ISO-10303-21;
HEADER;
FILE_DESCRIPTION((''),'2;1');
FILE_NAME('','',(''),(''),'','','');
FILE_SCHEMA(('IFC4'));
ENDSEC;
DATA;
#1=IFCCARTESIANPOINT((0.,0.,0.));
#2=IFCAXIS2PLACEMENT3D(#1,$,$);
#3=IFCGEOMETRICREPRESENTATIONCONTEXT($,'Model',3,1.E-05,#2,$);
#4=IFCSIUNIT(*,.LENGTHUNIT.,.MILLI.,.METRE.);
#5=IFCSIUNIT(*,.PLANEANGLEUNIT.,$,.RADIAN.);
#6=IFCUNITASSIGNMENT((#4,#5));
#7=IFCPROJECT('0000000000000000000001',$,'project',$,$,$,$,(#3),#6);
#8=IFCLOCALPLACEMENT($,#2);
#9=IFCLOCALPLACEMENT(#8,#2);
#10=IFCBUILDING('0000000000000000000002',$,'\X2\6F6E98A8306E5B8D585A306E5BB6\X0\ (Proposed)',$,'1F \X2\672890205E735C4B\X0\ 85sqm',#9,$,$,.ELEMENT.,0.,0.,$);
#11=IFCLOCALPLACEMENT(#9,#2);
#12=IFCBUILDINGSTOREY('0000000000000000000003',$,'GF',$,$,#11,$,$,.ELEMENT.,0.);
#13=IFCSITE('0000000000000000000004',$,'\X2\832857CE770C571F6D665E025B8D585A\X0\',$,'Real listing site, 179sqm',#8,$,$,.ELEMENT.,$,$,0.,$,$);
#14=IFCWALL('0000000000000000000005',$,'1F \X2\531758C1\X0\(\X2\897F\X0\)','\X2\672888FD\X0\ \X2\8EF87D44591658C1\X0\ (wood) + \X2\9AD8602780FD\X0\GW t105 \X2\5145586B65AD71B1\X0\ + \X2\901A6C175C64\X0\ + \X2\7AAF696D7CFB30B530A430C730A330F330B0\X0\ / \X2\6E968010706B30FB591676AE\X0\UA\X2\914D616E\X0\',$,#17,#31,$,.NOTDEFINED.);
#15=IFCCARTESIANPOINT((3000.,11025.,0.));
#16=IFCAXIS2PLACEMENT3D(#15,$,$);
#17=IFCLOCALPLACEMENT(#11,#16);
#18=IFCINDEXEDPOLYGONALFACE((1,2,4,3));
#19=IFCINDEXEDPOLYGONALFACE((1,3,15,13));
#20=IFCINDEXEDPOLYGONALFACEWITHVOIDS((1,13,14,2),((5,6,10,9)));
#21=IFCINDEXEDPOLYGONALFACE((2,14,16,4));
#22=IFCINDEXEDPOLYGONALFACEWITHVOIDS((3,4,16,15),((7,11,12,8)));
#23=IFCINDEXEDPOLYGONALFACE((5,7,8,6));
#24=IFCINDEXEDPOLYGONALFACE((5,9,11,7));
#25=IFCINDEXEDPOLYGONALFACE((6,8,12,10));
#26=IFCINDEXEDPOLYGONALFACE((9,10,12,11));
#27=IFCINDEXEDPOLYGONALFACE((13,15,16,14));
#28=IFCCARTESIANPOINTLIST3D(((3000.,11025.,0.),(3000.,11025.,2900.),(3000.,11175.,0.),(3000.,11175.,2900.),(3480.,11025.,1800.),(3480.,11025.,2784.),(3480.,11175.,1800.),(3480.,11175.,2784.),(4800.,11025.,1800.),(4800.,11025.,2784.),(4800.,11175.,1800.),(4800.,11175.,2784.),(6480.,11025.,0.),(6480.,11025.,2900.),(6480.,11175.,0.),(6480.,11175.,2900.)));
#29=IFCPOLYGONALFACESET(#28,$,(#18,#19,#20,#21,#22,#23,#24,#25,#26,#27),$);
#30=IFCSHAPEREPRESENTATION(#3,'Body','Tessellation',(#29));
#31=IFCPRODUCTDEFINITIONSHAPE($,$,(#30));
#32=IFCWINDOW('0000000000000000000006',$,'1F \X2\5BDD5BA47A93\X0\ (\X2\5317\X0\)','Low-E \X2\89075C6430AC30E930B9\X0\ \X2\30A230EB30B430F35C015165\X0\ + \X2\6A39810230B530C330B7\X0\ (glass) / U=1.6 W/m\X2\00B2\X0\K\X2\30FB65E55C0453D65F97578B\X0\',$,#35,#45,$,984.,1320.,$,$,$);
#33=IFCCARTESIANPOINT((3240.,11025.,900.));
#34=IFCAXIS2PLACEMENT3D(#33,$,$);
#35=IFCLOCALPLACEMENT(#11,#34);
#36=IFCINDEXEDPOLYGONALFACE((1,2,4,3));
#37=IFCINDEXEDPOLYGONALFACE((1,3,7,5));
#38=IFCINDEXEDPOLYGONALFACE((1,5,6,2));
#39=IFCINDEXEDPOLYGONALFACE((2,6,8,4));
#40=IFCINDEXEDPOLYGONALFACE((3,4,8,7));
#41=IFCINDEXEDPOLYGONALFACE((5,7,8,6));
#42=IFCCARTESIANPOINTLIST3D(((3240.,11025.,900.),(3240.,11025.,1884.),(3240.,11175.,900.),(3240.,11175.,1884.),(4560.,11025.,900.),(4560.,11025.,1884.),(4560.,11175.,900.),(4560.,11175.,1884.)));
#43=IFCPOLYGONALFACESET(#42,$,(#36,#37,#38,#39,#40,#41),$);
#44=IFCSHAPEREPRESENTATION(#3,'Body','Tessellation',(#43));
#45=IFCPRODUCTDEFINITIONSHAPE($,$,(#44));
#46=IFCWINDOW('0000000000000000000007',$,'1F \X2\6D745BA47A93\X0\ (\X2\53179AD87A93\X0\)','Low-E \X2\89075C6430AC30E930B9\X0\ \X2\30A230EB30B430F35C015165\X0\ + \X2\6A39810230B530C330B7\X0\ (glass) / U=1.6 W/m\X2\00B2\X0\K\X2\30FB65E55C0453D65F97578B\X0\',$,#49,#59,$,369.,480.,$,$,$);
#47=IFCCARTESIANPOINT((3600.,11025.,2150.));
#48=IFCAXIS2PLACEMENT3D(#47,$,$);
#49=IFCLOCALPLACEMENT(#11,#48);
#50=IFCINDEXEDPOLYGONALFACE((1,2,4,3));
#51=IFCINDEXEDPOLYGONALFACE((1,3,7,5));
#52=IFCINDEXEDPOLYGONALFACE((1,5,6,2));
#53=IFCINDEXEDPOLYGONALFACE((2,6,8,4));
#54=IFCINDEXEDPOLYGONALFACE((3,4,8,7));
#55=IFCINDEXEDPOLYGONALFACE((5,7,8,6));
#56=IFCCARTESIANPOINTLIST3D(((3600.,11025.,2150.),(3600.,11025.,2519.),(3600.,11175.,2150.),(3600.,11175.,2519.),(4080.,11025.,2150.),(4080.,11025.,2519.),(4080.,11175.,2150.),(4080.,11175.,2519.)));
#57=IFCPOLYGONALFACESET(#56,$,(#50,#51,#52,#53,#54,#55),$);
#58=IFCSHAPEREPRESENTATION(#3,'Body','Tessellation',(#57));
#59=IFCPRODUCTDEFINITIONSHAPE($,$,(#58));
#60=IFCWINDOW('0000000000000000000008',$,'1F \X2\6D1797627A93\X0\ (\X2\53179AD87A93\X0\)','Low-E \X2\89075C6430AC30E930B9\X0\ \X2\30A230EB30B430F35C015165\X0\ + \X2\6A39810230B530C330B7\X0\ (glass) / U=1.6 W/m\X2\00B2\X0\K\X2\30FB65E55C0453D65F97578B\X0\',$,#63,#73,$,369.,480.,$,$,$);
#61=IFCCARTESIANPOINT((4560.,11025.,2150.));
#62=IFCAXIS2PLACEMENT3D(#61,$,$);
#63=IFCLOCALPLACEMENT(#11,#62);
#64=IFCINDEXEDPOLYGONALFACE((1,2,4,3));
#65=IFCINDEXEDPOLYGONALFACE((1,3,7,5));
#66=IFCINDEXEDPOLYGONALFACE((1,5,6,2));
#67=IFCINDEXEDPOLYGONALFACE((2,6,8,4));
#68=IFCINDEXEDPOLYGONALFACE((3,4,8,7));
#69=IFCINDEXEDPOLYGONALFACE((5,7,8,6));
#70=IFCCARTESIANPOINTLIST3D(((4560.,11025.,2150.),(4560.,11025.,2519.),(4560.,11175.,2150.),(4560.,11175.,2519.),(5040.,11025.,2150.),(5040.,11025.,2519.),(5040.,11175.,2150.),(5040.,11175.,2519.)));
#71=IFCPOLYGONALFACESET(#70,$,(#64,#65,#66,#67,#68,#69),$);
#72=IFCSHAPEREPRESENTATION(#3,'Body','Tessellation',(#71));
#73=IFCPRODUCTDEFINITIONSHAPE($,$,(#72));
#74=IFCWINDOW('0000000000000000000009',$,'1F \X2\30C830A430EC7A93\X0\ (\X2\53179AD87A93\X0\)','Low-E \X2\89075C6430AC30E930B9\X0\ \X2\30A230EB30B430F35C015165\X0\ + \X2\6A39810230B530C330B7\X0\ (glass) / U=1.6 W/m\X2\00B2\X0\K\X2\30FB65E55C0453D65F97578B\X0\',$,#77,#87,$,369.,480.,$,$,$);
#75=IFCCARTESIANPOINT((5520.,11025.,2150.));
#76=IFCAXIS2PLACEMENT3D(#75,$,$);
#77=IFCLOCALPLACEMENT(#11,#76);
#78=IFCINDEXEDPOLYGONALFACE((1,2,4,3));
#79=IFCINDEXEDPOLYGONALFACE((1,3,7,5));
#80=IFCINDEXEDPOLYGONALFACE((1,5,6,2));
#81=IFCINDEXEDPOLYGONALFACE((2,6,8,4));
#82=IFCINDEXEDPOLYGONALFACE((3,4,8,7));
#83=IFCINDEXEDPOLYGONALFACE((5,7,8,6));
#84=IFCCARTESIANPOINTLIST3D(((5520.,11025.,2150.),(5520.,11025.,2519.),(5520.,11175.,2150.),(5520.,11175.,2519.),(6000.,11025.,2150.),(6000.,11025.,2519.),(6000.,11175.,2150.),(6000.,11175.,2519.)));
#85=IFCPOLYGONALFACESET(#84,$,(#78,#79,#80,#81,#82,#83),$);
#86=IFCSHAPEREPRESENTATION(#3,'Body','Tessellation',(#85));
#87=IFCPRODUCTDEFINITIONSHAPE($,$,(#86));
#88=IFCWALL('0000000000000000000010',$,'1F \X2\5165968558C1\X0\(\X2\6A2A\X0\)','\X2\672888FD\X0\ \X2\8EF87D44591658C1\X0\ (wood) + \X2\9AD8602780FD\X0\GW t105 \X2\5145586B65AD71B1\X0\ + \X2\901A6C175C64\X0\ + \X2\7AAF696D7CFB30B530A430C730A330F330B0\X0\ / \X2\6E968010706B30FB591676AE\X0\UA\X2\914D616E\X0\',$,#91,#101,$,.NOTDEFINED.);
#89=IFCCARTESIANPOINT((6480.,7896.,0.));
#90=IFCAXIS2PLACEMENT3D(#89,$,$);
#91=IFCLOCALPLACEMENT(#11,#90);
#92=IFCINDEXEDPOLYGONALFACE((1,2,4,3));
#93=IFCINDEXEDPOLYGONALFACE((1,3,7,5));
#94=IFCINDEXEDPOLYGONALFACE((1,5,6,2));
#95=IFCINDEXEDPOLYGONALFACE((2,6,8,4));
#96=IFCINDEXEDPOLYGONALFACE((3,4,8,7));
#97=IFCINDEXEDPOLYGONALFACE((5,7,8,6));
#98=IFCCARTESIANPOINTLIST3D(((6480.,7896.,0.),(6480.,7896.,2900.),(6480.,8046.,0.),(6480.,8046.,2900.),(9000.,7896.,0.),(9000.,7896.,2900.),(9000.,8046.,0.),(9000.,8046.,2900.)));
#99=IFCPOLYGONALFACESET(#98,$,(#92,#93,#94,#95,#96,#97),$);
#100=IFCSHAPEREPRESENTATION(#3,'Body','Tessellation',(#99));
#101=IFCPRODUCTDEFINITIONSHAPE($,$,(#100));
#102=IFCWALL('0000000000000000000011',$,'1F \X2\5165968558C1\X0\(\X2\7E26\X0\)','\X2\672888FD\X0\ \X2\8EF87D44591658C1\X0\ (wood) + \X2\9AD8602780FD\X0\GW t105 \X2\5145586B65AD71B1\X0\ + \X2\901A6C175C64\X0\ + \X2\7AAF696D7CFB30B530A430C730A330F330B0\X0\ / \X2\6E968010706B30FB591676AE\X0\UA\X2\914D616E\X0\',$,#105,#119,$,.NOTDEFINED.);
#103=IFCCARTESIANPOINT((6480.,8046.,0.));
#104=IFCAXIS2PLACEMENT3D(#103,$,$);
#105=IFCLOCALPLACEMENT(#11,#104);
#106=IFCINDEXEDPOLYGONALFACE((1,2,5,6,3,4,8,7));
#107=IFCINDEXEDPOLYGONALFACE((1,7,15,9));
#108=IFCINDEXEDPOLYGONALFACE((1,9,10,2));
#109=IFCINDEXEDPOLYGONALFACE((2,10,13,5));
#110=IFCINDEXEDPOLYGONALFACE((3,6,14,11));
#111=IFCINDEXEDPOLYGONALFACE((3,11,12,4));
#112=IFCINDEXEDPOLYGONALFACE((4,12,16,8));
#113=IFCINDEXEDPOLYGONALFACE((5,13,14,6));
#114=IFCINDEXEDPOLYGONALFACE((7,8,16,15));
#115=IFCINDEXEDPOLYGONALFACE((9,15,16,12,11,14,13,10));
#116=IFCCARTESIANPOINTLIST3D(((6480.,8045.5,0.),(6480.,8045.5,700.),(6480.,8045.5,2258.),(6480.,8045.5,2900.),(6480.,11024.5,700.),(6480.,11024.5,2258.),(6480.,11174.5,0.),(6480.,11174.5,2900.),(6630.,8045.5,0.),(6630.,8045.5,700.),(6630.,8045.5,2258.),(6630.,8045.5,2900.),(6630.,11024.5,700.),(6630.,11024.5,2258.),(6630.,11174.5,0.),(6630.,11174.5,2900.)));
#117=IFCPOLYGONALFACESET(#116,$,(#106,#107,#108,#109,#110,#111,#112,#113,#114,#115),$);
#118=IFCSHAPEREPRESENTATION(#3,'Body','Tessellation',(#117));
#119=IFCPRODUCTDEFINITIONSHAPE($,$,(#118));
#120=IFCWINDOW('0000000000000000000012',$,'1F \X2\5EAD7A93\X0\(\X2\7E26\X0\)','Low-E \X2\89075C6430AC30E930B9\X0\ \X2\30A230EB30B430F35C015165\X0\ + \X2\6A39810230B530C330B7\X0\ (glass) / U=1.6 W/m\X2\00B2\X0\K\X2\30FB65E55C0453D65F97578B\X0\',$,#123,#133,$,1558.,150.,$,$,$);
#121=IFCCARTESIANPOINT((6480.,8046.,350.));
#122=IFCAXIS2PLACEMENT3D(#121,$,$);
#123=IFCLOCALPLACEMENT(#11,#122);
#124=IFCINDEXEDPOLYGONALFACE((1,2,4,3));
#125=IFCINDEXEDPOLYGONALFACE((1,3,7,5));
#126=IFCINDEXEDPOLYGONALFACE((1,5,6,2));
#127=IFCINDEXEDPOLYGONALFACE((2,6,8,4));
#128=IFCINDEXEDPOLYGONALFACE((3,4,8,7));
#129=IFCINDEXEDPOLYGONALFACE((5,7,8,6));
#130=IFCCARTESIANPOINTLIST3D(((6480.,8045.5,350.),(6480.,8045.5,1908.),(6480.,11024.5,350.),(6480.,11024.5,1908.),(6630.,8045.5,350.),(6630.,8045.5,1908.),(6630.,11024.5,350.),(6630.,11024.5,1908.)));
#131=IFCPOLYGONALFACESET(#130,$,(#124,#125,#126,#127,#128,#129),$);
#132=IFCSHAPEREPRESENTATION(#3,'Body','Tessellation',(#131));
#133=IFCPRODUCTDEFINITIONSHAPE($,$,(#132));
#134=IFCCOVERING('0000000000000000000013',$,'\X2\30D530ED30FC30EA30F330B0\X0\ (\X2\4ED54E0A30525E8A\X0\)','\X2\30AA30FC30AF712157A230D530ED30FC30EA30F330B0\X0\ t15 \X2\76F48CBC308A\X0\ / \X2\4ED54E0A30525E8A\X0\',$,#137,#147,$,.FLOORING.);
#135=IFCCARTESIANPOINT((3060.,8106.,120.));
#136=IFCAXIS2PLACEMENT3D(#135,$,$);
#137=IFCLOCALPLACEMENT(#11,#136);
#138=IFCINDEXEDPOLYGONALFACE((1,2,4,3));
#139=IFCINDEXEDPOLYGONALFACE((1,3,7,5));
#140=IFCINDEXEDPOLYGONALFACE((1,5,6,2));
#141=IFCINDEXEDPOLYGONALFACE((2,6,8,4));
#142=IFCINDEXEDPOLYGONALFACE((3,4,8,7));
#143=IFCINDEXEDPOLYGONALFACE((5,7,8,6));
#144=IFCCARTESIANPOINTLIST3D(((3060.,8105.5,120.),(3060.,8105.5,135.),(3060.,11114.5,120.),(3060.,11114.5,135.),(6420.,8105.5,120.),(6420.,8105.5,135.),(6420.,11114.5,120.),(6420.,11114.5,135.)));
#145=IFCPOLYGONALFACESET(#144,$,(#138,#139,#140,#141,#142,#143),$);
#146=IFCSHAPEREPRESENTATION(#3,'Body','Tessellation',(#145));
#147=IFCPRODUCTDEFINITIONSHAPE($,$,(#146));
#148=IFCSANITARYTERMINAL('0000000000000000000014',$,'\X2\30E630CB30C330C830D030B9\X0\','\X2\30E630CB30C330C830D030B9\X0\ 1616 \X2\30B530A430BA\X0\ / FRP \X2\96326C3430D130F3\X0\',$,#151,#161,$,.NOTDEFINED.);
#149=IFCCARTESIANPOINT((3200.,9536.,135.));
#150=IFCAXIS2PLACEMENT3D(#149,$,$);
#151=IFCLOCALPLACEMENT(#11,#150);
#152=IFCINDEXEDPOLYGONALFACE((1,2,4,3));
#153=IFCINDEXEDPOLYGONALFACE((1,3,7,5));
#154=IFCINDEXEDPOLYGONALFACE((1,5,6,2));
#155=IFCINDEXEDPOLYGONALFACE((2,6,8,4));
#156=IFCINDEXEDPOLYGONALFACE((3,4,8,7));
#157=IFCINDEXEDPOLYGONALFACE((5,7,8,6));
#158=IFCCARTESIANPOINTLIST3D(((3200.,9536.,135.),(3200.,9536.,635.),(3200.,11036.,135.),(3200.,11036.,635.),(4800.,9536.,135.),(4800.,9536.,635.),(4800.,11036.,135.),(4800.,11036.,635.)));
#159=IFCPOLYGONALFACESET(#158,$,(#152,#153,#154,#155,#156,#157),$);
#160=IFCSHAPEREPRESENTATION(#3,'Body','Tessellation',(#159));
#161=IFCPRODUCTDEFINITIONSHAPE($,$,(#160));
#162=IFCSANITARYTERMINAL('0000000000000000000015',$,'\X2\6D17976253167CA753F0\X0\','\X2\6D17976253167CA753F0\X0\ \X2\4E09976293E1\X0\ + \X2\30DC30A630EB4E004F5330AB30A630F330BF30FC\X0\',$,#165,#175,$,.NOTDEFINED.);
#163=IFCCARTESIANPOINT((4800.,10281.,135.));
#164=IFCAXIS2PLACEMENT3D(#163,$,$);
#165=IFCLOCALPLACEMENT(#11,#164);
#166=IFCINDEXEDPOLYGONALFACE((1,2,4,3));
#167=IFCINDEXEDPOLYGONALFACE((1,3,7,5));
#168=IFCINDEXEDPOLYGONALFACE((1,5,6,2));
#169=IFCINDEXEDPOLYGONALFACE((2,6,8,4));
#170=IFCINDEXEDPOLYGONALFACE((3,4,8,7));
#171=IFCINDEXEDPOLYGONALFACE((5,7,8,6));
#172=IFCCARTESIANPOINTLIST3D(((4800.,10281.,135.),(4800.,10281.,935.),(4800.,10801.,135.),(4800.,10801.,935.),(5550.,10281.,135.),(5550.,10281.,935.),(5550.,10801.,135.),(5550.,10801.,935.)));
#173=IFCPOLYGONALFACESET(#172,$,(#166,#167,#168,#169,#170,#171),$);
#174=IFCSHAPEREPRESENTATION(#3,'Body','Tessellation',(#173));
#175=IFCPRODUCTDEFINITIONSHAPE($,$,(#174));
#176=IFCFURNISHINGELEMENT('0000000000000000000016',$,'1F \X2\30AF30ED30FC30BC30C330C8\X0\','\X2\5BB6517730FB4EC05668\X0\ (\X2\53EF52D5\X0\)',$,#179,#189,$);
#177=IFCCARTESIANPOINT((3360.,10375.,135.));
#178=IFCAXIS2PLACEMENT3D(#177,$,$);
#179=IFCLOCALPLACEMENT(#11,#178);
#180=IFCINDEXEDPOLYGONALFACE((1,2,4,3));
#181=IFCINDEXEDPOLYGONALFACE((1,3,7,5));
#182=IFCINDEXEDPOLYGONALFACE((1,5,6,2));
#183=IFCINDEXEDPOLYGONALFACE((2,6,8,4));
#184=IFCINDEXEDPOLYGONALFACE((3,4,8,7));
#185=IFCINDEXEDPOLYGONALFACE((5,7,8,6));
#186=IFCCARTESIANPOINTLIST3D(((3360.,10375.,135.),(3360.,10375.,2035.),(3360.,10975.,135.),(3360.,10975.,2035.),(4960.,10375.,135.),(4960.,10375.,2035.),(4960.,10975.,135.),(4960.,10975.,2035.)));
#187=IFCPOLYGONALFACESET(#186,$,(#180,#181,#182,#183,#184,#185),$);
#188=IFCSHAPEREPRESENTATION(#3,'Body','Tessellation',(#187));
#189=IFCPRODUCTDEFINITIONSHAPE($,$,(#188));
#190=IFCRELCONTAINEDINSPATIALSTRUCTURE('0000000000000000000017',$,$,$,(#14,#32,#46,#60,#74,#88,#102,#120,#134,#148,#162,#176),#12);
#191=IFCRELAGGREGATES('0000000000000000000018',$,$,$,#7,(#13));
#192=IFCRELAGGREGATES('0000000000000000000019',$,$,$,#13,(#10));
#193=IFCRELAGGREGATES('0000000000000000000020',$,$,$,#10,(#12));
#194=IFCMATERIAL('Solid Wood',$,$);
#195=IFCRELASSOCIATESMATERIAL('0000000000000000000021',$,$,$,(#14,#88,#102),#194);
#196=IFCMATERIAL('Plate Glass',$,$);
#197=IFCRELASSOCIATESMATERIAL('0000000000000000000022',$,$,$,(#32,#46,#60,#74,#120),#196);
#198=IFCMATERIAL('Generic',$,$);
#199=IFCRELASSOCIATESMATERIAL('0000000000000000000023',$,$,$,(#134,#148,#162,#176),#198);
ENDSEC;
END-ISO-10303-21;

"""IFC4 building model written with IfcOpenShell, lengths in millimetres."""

from ifc_helpers import new_model, si_unit, frame, frame_2d, origin, place, context, project, spatial, rectangle, extrude, material, element, fill, save


model = new_model("IFC4")

# Units and contexts
model_context = context("Model", 3, precision=1e-05, world=origin())
ifc_project = project(units=[si_unit("LENGTHUNIT", "METRE", prefix="MILLI"), si_unit("PLANEANGLEUNIT", "RADIAN")], contexts=[model_context])

# Site, building, storey
site_placement = place(None, origin())
site = spatial("IfcSite", under=ifc_project, at=site_placement, Name="茨城県土浦市宍塚", ObjectType="Real listing site, 179sqm", CompositionType="ELEMENT", RefElevation=0.0)
building_placement = place(site_placement, origin())
building = spatial("IfcBuilding", under=site, at=building_placement, Name="潮風の宍塚の家 (Proposed)", ObjectType="1F 木造平屋 85sqm", CompositionType="ELEMENT", ElevationOfRefHeight=0.0, ElevationOfTerrain=0.0)
storey_placement = place(building_placement, origin())
storey = spatial("IfcBuildingStorey", under=building, at=storey_placement, Name="GF", CompositionType="ELEMENT", Elevation=0.0)

# Shared definitions
ifc_material_1 = material(Name="Solid Wood")

# Wall, openings, windows
wall_1_placement = place(storey_placement, frame((3000.0, 11025.0, 0.0)))
wall_1 = element("IfcWall", 1, at=wall_1_placement, inside=storey, material=ifc_material_1, Name="1F 北壁(西)", Description="木製 軸組外壁 (wood) + 高性能GW t105 充填断熱 + 通気層 + 窯業系サイディング / 準耐火・外皮UA配慮", PredefinedType="NOTDEFINED", context=model_context, shape_type="SweptSolid", body=[
    extrude(rectangle(XDim=3480.0, YDim=150.0, at=frame_2d((1740.0, 75.0))), frame((3000.0, 11025.0, 0.0)), (0.0, 0.0, 1.0), 2900.0),
])
opening_1_placement = place(storey_placement, frame((3240.0, 11025.0, 900.0)))
opening_1 = element("IfcOpeningElement", 2, at=opening_1_placement, cuts=wall_1, PredefinedType="NOTDEFINED", context=model_context, shape_type="SweptSolid", body=[
    extrude(rectangle(XDim=1320.0, YDim=150.0, at=frame_2d((660.0, 75.0))), frame((3240.0, 11025.0, 900.0)), (0.0, 0.0, 1.0), 984.0),
])
opening_2_placement = place(storey_placement, frame((3600.0, 11025.0, 2150.0)))
opening_2 = element("IfcOpeningElement", 3, at=opening_2_placement, cuts=wall_1, PredefinedType="NOTDEFINED", context=model_context, shape_type="SweptSolid", body=[
    extrude(rectangle(XDim=480.0, YDim=150.0, at=frame_2d((240.0, 75.0))), frame((3600.0, 11025.0, 2150.0)), (0.0, 0.0, 1.0), 369.0),
])
opening_3_placement = place(storey_placement, frame((4560.0, 11025.0, 2150.0)))
opening_3 = element("IfcOpeningElement", 4, at=opening_3_placement, cuts=wall_1, PredefinedType="NOTDEFINED", context=model_context, shape_type="SweptSolid", body=[
    extrude(rectangle(XDim=480.0, YDim=150.0, at=frame_2d((240.0, 75.0))), frame((4560.0, 11025.0, 2150.0)), (0.0, 0.0, 1.0), 369.0),
])
opening_4_placement = place(storey_placement, frame((5520.0, 11025.0, 2150.0)))
opening_4 = element("IfcOpeningElement", 5, at=opening_4_placement, cuts=wall_1, PredefinedType="NOTDEFINED", context=model_context, shape_type="SweptSolid", body=[
    extrude(rectangle(XDim=480.0, YDim=150.0, at=frame_2d((240.0, 75.0))), frame((5520.0, 11025.0, 2150.0)), (0.0, 0.0, 1.0), 369.0),
])
ifc_material_2 = material(Name="Plate Glass")
window_1_placement = place(storey_placement, frame((3240.0, 11025.0, 900.0)))
window_1 = element("IfcWindow", 6, at=window_1_placement, inside=storey, material=ifc_material_2, Name="1F 寝室窓 (北)", Description="Low-E 複層ガラス アルゴン封入 + 樹脂サッシ (glass) / U=1.6 W/m²K・日射取得型", OverallHeight=984.0, OverallWidth=1320.0, context=model_context, shape_type="SweptSolid", body=[
    extrude(rectangle(XDim=1320.0, YDim=150.0, at=frame_2d((660.0, 75.0))), frame((3240.0, 11025.0, 900.0)), (0.0, 0.0, 1.0), 984.0),
])
fill(opening_1, window_1)
window_2_placement = place(storey_placement, frame((3600.0, 11025.0, 2150.0)))
window_2 = element("IfcWindow", 7, at=window_2_placement, inside=storey, material=ifc_material_2, Name="1F 浴室窓 (北高窓)", Description="Low-E 複層ガラス アルゴン封入 + 樹脂サッシ (glass) / U=1.6 W/m²K・日射取得型", OverallHeight=369.0, OverallWidth=480.0, context=model_context, shape_type="SweptSolid", body=[
    extrude(rectangle(XDim=480.0, YDim=150.0, at=frame_2d((240.0, 75.0))), frame((3600.0, 11025.0, 2150.0)), (0.0, 0.0, 1.0), 369.0),
])
fill(opening_2, window_2)
window_3_placement = place(storey_placement, frame((4560.0, 11025.0, 2150.0)))
window_3 = element("IfcWindow", 8, at=window_3_placement, inside=storey, material=ifc_material_2, Name="1F 洗面窓 (北高窓)", Description="Low-E 複層ガラス アルゴン封入 + 樹脂サッシ (glass) / U=1.6 W/m²K・日射取得型", OverallHeight=369.0, OverallWidth=480.0, context=model_context, shape_type="SweptSolid", body=[
    extrude(rectangle(XDim=480.0, YDim=150.0, at=frame_2d((240.0, 75.0))), frame((4560.0, 11025.0, 2150.0)), (0.0, 0.0, 1.0), 369.0),
])
fill(opening_3, window_3)
window_4_placement = place(storey_placement, frame((5520.0, 11025.0, 2150.0)))
window_4 = element("IfcWindow", 9, at=window_4_placement, inside=storey, material=ifc_material_2, Name="1F トイレ窓 (北高窓)", Description="Low-E 複層ガラス アルゴン封入 + 樹脂サッシ (glass) / U=1.6 W/m²K・日射取得型", OverallHeight=369.0, OverallWidth=480.0, context=model_context, shape_type="SweptSolid", body=[
    extrude(rectangle(XDim=480.0, YDim=150.0, at=frame_2d((240.0, 75.0))), frame((5520.0, 11025.0, 2150.0)), (0.0, 0.0, 1.0), 369.0),
])
fill(opening_4, window_4)

# Wall
wall_2_placement = place(storey_placement, frame((6480.0, 7896.0, 0.0)))
element("IfcWall", 10, at=wall_2_placement, inside=storey, material=ifc_material_1, Name="1F 入隅壁(横)", Description="木製 軸組外壁 (wood) + 高性能GW t105 充填断熱 + 通気層 + 窯業系サイディング / 準耐火・外皮UA配慮", PredefinedType="NOTDEFINED", context=model_context, shape_type="SweptSolid", body=[
    extrude(rectangle(XDim=2520.0, YDim=150.0, at=frame_2d((1260.0, 75.0))), frame((6480.0, 7896.0, 0.0)), (0.0, 0.0, 1.0), 2900.0),
])

# Wall, opening, window
wall_3_placement = place(storey_placement, frame((6480.0, 8046.0, 0.0)))
wall_3 = element("IfcWall", 11, at=wall_3_placement, inside=storey, material=ifc_material_1, Name="1F 入隅壁(縦)", Description="木製 軸組外壁 (wood) + 高性能GW t105 充填断熱 + 通気層 + 窯業系サイディング / 準耐火・外皮UA配慮", PredefinedType="NOTDEFINED", context=model_context, shape_type="SweptSolid", body=[
    extrude(rectangle(XDim=150.0, YDim=3129.0, at=frame_2d((75.0, 1564.0))), frame((6480.0, 8046.0, 0.0)), (0.0, 0.0, 1.0), 2900.0),
])
opening_5_placement = place(storey_placement, frame((6480.0, 8046.0, 350.0)))
opening_5 = element("IfcOpeningElement", 12, at=opening_5_placement, cuts=wall_3, PredefinedType="NOTDEFINED", context=model_context, shape_type="SweptSolid", body=[
    extrude(rectangle(XDim=150.0, YDim=2979.0, at=frame_2d((75.0, 1489.0))), frame((6480.0, 8046.0, 350.0)), (0.0, 0.0, 1.0), 1558.0),
])
window_5_placement = place(storey_placement, frame((6480.0, 8046.0, 350.0)))
window_5 = element("IfcWindow", 13, at=window_5_placement, inside=storey, material=ifc_material_2, Name="1F 庭窓(縦)", Description="Low-E 複層ガラス アルゴン封入 + 樹脂サッシ (glass) / U=1.6 W/m²K・日射取得型", OverallHeight=1558.0, OverallWidth=150.0, context=model_context, shape_type="SweptSolid", body=[
    extrude(rectangle(XDim=150.0, YDim=2979.0, at=frame_2d((75.0, 1489.0))), frame((6480.0, 8046.0, 350.0)), (0.0, 0.0, 1.0), 1558.0),
])
fill(opening_5, window_5)

# Covering
ifc_material_3 = material(Name="Generic")
covering_placement = place(storey_placement, frame((3060.0, 8106.0, 120.0)))
element("IfcCovering", 14, at=covering_placement, inside=storey, material=ifc_material_3, Name="フローリング (仕上げ床)", Description="オーク無垢フローリング t15 直貼り / 仕上げ床", PredefinedType="FLOORING", context=model_context, shape_type="SweptSolid", body=[
    extrude(rectangle(XDim=3360.0, YDim=3009.0, at=frame_2d((1680.0, 1504.0))), frame((3060.0, 8106.0, 120.0)), (0.0, 0.0, 1.0), 15.0),
])

# Sanitary terminals
sanitary_terminal_1_placement = place(storey_placement, frame((3200.0, 9536.0, 135.0)))
element("IfcSanitaryTerminal", 15, at=sanitary_terminal_1_placement, inside=storey, material=ifc_material_3, Name="ユニットバス", Description="ユニットバス 1616 サイズ / FRP 防水パン", PredefinedType="NOTDEFINED", context=model_context, shape_type="SweptSolid", body=[
    extrude(rectangle(XDim=1600.0, YDim=1500.0, at=frame_2d((800.0, 750.0))), frame((3200.0, 9536.0, 135.0)), (0.0, 0.0, 1.0), 500.0),
])
sanitary_terminal_2_placement = place(storey_placement, frame((4800.0, 10281.0, 135.0)))
element("IfcSanitaryTerminal", 16, at=sanitary_terminal_2_placement, inside=storey, material=ifc_material_3, Name="洗面化粧台", Description="洗面化粧台 三面鏡 + ボウル一体カウンター", PredefinedType="NOTDEFINED", context=model_context, shape_type="SweptSolid", body=[
    extrude(rectangle(XDim=750.0, YDim=520.0, at=frame_2d((375.0, 260.0))), frame((4800.0, 10281.0, 135.0)), (0.0, 0.0, 1.0), 800.0),
])

# Furnishing element
furnishing_1_placement = place(storey_placement, frame((3360.0, 10375.0, 135.0)))
element("IfcFurnishingElement", 17, at=furnishing_1_placement, inside=storey, material=ifc_material_3, Name="1F クローゼット", Description="家具・什器 (可動)", context=model_context, shape_type="SweptSolid", body=[
    extrude(rectangle(XDim=1600.0, YDim=600.0, at=frame_2d((800.0, 300.0))), frame((3360.0, 10375.0, 135.0)), (0.0, 0.0, 1.0), 1900.0),
])

save(model, "model.ifc")
